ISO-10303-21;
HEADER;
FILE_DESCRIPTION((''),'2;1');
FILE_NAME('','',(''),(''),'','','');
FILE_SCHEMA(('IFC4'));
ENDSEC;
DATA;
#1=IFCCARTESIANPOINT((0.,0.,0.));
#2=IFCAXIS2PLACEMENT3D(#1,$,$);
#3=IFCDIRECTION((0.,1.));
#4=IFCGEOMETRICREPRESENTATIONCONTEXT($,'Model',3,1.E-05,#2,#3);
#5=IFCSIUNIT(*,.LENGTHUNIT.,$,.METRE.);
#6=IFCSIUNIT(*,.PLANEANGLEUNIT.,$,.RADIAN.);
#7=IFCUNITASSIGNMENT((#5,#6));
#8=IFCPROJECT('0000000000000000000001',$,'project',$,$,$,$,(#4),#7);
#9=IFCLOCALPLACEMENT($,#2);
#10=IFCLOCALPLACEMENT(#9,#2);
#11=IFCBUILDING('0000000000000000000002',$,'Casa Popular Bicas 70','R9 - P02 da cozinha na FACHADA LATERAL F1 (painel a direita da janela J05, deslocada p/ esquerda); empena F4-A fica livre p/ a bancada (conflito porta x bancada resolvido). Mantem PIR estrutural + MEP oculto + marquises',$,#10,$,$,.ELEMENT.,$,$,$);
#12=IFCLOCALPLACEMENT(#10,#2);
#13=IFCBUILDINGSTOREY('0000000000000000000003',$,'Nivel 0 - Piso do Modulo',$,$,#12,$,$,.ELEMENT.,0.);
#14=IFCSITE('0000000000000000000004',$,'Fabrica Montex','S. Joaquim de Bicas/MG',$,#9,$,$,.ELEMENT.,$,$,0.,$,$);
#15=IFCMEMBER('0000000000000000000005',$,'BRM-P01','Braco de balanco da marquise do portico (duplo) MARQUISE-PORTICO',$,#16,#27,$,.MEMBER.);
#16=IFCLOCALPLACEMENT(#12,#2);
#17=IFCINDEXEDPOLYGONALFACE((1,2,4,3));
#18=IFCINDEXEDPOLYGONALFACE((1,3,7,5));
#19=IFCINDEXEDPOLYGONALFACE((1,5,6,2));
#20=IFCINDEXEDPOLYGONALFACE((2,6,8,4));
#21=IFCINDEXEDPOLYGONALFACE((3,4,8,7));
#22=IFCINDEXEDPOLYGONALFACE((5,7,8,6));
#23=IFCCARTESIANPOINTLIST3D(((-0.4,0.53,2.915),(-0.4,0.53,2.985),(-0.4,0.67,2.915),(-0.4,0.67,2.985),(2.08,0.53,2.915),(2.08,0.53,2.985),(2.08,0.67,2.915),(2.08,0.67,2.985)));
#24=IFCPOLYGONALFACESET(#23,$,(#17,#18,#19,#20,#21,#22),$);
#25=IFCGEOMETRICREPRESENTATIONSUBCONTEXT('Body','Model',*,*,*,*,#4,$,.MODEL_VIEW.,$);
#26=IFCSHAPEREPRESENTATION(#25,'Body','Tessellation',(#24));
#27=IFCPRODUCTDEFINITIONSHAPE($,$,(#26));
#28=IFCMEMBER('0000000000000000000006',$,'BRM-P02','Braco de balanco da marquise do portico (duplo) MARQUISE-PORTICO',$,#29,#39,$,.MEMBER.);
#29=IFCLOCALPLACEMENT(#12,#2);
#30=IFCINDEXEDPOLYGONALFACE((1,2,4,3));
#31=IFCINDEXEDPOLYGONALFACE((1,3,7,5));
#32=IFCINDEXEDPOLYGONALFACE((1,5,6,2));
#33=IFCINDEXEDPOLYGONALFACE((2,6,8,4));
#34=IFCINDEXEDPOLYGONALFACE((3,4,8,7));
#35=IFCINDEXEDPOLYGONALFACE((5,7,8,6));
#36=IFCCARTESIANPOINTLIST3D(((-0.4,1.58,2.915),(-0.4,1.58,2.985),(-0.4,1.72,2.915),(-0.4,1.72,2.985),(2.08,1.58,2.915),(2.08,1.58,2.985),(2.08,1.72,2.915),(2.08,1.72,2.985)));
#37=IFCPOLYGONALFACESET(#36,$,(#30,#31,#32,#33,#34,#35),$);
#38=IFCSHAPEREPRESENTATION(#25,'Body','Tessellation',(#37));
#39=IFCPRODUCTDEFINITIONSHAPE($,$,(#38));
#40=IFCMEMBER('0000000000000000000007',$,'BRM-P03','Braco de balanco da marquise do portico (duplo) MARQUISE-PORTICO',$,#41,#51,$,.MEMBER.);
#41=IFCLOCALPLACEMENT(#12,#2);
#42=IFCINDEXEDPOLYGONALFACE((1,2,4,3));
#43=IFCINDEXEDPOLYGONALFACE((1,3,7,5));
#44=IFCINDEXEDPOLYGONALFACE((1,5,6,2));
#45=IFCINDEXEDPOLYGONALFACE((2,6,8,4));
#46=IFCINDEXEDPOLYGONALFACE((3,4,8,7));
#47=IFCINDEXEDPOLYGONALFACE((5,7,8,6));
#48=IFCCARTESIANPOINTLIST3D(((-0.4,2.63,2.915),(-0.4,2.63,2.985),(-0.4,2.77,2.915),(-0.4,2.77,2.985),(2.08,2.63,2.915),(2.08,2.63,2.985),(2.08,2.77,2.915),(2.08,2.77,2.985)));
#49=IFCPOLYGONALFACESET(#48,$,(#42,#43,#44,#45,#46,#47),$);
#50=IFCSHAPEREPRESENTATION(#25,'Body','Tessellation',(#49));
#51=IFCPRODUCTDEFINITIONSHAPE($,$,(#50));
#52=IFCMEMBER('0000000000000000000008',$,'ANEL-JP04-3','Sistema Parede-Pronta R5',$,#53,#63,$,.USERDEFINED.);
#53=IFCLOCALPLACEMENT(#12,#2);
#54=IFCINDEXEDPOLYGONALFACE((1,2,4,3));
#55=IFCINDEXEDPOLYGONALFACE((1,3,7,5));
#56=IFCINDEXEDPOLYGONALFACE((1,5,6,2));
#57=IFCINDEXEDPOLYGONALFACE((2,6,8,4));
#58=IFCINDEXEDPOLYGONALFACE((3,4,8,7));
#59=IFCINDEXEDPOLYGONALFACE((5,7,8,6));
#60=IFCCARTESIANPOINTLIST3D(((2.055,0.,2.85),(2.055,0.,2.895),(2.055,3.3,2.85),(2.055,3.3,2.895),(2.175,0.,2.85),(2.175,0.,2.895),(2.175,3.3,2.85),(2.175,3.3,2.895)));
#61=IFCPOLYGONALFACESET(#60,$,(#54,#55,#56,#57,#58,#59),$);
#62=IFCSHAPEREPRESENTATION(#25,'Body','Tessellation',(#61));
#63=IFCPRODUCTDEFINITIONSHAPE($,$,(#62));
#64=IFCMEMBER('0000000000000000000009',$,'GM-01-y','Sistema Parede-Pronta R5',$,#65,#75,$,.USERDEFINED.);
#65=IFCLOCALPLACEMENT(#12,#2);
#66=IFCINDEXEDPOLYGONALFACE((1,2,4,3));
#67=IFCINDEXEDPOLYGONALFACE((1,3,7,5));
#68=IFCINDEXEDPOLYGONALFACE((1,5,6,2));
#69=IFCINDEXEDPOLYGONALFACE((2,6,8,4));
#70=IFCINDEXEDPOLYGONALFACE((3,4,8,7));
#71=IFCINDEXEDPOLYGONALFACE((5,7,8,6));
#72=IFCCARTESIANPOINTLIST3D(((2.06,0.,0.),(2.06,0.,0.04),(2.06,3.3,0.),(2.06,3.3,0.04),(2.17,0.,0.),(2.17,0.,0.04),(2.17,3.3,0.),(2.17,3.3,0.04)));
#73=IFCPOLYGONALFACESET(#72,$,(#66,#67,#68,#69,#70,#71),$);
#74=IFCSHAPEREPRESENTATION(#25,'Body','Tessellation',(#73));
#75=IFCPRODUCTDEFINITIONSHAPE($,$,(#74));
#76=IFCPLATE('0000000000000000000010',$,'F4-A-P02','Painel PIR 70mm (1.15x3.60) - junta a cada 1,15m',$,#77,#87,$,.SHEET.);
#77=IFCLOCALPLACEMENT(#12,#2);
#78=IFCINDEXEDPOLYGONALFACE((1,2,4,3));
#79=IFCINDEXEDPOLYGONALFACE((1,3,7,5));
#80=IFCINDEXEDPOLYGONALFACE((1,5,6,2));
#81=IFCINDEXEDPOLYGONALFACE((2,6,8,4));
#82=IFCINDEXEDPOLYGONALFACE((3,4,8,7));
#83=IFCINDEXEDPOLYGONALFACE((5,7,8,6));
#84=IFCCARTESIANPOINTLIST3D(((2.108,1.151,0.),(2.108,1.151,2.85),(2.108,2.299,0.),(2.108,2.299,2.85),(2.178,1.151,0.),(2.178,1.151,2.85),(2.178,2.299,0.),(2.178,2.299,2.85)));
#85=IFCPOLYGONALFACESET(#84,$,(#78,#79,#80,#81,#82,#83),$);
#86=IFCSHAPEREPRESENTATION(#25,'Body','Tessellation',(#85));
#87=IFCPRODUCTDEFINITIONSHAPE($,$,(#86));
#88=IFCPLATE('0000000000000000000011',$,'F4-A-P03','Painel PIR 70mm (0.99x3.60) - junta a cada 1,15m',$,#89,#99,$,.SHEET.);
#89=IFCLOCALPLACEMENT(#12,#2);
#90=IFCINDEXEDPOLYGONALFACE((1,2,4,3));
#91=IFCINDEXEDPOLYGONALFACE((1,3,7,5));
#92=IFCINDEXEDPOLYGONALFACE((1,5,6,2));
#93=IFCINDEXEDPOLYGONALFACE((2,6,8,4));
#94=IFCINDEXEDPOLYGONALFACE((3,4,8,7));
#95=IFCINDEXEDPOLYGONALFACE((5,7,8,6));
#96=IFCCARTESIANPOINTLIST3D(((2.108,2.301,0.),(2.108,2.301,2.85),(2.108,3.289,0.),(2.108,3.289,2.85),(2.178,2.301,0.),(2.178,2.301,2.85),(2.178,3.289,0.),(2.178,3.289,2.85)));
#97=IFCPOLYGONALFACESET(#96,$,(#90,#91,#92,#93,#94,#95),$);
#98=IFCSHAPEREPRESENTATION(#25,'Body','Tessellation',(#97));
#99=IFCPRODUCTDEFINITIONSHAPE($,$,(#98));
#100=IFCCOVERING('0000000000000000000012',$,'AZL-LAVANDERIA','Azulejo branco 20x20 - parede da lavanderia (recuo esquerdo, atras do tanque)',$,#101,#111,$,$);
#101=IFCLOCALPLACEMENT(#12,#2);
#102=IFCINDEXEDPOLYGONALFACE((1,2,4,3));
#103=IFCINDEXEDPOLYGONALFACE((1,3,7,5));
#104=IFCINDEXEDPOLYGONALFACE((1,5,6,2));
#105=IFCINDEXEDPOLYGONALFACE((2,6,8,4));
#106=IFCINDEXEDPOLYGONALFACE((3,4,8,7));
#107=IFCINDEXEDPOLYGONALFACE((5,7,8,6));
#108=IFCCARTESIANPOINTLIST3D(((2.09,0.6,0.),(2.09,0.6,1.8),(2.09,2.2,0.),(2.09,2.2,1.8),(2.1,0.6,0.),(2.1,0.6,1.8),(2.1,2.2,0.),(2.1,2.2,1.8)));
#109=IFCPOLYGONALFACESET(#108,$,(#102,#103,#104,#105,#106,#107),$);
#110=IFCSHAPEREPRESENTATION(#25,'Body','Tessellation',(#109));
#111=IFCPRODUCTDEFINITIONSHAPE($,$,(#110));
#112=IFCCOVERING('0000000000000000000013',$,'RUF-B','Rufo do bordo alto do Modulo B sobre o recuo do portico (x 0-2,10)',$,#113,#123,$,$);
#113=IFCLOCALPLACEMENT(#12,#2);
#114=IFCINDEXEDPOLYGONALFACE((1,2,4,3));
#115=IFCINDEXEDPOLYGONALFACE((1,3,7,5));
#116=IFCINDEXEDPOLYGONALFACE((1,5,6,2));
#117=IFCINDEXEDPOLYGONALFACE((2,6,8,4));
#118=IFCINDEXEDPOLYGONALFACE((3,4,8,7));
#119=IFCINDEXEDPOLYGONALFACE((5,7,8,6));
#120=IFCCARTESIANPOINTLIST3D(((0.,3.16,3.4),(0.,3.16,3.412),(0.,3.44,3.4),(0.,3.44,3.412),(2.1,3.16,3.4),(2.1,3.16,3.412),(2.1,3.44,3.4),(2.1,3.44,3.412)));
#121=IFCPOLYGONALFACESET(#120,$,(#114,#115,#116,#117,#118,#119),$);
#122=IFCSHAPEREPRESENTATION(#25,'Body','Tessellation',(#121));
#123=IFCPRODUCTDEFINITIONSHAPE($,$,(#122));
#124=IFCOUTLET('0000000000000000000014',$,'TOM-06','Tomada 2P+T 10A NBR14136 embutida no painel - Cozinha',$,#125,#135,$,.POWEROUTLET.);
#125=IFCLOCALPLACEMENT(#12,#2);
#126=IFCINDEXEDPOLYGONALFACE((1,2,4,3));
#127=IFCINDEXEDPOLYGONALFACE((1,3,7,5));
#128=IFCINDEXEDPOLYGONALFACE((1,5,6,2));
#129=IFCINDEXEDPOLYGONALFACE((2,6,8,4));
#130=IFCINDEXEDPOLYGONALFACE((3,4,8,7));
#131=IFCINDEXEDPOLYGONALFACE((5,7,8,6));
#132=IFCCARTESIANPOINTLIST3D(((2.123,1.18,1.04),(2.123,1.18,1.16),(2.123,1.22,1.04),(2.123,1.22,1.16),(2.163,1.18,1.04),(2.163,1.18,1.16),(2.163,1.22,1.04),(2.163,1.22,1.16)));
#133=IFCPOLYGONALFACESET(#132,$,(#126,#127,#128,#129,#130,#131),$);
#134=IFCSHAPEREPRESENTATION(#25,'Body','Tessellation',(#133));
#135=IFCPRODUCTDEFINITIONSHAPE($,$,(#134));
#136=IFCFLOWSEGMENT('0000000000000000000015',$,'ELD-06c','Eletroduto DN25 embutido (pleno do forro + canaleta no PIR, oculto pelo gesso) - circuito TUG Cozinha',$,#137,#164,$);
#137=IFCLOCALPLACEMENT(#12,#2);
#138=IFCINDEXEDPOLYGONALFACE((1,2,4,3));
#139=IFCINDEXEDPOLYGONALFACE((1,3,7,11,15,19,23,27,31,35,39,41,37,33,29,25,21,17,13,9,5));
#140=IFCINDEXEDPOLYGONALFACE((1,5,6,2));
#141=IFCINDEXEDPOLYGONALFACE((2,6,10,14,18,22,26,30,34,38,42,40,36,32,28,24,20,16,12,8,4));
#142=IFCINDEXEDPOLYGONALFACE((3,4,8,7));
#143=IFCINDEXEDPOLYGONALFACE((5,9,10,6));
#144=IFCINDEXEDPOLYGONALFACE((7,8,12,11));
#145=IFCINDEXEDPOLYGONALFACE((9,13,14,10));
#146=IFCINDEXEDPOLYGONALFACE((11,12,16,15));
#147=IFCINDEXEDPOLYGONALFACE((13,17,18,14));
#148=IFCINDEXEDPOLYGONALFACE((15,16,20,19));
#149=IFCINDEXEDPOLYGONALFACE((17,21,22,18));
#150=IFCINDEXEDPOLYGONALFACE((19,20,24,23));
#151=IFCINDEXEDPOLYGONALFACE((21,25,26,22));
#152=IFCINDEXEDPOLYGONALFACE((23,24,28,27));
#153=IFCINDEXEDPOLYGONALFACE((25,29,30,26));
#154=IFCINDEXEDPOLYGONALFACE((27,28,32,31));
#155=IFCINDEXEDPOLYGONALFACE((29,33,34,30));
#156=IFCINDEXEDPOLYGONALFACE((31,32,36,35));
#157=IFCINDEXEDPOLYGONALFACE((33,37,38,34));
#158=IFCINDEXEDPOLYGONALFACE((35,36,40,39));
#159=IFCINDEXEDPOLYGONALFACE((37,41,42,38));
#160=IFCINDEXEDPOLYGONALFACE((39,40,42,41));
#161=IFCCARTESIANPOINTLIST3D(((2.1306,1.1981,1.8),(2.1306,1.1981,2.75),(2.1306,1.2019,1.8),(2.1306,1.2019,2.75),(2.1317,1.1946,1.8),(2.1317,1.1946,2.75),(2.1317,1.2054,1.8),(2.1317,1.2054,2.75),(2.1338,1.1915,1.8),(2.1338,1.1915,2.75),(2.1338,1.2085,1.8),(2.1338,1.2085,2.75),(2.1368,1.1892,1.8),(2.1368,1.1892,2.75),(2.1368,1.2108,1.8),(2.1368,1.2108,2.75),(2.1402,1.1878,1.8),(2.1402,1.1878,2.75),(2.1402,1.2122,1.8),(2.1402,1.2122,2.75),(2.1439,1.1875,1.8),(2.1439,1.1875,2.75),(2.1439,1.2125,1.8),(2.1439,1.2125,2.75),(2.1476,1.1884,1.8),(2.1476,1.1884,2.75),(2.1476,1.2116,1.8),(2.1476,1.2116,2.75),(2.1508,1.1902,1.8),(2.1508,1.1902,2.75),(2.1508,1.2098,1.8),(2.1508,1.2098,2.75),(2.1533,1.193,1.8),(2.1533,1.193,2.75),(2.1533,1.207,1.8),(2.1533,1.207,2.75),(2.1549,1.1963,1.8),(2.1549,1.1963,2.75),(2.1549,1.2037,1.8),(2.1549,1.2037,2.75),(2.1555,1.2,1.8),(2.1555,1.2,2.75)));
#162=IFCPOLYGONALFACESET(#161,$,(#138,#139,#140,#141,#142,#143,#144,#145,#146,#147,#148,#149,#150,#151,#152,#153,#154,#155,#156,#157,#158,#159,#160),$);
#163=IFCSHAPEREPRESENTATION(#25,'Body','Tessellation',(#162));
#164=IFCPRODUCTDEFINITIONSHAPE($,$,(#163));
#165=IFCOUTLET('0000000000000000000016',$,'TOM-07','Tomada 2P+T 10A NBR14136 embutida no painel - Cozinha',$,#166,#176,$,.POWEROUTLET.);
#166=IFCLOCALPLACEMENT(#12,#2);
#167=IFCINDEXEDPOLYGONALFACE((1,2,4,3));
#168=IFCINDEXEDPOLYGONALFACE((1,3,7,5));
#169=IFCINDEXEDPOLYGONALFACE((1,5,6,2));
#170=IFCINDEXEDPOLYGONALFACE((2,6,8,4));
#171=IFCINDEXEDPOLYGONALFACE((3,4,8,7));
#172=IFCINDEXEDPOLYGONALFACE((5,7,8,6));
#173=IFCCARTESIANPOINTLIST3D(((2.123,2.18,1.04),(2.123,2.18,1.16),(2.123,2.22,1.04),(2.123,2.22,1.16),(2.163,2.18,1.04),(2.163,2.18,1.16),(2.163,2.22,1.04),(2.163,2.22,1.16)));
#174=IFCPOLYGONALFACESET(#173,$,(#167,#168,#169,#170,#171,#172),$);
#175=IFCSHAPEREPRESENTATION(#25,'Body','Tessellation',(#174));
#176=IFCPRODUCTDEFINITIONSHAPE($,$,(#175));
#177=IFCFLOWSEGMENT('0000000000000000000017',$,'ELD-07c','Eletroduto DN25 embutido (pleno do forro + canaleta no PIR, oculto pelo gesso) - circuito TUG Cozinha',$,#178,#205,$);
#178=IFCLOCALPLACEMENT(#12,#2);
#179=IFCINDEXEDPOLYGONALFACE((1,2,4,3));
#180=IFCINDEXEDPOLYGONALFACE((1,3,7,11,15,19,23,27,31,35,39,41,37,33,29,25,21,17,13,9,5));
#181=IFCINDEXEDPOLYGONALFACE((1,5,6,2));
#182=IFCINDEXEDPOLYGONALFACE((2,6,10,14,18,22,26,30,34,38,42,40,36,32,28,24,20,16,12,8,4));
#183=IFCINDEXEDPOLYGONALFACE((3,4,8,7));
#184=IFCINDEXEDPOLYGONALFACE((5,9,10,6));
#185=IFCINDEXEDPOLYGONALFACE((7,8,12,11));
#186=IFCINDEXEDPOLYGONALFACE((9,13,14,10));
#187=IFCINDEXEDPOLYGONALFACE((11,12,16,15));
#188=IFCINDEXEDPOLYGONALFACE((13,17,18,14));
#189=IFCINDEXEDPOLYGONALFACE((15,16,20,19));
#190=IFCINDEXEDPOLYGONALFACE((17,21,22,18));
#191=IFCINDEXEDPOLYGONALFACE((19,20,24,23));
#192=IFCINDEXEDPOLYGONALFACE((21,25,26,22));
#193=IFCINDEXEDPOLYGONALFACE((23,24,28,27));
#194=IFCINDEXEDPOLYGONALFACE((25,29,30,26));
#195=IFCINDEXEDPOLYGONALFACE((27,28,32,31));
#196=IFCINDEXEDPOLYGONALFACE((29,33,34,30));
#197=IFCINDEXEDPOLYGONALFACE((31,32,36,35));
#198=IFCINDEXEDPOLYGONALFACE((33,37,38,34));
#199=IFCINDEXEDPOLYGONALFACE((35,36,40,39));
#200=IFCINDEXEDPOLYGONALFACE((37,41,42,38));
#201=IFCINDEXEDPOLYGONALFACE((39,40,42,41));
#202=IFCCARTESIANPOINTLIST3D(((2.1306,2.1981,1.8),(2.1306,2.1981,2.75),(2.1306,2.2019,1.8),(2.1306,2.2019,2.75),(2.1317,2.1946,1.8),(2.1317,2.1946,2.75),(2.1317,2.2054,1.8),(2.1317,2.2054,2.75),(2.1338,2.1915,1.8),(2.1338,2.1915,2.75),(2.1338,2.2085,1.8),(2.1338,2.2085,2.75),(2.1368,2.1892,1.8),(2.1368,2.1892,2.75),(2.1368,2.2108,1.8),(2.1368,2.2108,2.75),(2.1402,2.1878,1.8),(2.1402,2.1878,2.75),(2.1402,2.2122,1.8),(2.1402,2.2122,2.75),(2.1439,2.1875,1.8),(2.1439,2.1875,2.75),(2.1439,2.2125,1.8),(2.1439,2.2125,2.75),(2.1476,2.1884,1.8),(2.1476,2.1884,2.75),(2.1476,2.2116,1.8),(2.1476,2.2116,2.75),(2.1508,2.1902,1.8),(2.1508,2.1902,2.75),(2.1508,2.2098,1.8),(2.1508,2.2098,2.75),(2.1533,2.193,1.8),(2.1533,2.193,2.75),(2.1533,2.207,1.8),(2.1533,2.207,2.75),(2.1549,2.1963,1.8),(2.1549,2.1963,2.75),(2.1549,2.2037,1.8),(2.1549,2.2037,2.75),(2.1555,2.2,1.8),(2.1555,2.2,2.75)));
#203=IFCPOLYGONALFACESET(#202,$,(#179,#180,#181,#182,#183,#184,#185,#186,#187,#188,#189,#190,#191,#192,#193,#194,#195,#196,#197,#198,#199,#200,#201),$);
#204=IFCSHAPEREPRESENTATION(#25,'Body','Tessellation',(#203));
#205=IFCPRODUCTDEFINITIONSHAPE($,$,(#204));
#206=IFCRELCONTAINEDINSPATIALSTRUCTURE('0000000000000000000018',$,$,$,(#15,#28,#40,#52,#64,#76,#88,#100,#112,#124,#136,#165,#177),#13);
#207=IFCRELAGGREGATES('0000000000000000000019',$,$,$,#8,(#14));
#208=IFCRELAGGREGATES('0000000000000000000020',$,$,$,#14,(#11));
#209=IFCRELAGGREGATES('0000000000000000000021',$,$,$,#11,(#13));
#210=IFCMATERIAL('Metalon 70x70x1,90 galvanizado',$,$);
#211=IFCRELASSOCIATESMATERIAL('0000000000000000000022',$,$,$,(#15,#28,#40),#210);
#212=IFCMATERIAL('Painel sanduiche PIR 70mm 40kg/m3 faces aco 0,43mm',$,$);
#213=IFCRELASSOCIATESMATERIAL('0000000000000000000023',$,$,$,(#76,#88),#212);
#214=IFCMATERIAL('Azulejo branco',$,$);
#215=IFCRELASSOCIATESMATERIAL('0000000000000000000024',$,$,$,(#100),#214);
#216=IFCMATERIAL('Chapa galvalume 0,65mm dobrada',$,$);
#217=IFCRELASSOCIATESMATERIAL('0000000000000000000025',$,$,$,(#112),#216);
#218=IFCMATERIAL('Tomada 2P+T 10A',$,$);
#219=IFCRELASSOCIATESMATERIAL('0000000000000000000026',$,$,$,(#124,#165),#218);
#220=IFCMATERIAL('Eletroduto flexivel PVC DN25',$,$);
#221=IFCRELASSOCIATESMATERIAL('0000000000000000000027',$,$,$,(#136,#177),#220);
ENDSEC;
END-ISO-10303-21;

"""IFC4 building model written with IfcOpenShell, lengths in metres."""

from ifc_helpers import new_model, si_unit, direction, frame, frame_2d, origin, origin_2d, place, context, subcontext, project, spatial, rectangle, circle, extrude, material, element, save


model = new_model("IFC4")

# Units and contexts
model_context = context("Model", 3, precision=1e-05, world=origin(), true_north=direction((0.0, 1.0)))
body_context = subcontext(model_context, "Body", "Model", "MODEL_VIEW")
ifc_project = project(units=[si_unit("LENGTHUNIT", "METRE"), si_unit("PLANEANGLEUNIT", "RADIAN")], contexts=[model_context])

# Site, building, storey
site_placement = place(None, origin())
site = spatial("IfcSite", under=ifc_project, at=site_placement, Name="Fabrica Montex", Description="S. Joaquim de Bicas/MG", CompositionType="ELEMENT", RefElevation=0.0)
building_placement = place(site_placement, origin())
building = spatial("IfcBuilding", under=site, at=building_placement, Name="Casa Popular Bicas 70", Description="R9 - P02 da cozinha na FACHADA LATERAL F1 (painel a direita da janela J05, deslocada p/ esquerda); empena F4-A fica livre p/ a bancada (conflito porta x bancada resolvido). Mantem PIR estrutural + MEP oculto + marquises", CompositionType="ELEMENT")
storey_placement = place(building_placement, origin())
storey = spatial("IfcBuildingStorey", under=building, at=storey_placement, Name="Nivel 0 - Piso do Modulo", CompositionType="ELEMENT", Elevation=0.0)

# Members
ifc_material_1 = material(Name="Metalon 70x70x1,90 galvanizado")
for number, where, z_axis, x_axis, name in (
    (1, (2.08, 0.6, 2.95), (-1.0, 0.0, 0.0), (0.0, 0.0, 1.0), "BRM-P01"),
    (2, (2.08, 1.65, 2.95), (-1.0, 0.0, 0.0), (0.0, 0.0, 1.0), "BRM-P02"),
    (3, (2.08, 2.7, 2.95), (-1.0, 0.0, 0.0), (0.0, 0.0, 1.0), "BRM-P03"),
):
    element("IfcMember", number, at=place(storey_placement, frame(where, z_axis=z_axis, x_axis=x_axis)), inside=storey, material=ifc_material_1, Name=name, Description="Braco de balanco da marquise do portico (duplo) MARQUISE-PORTICO", PredefinedType="MEMBER", context=body_context, shape_type="SweptSolid", body=[
        extrude(rectangle(XDim=0.07, YDim=0.14, at=origin_2d()), origin(), (0.0, 0.0, 1.0), 2.48),
    ])
member_1_placement = place(storey_placement, frame((2.115, 1.65, 2.85)))
element("IfcMember", 4, at=member_1_placement, inside=storey, Name="ANEL-JP04-3", Description="Sistema Parede-Pronta R5", PredefinedType="USERDEFINED", context=body_context, shape_type="SweptSolid", body=[
    extrude(rectangle(XDim=0.12, YDim=3.3, at=origin_2d()), origin(), (0.0, 0.0, 1.0), 0.045),
])
member_2_placement = place(storey_placement, frame((2.115, 1.65, 0.0)))
element("IfcMember", 5, at=member_2_placement, inside=storey, Name="GM-01-y", Description="Sistema Parede-Pronta R5", PredefinedType="USERDEFINED", context=body_context, shape_type="SweptSolid", body=[
    extrude(rectangle(XDim=0.11, YDim=3.3, at=origin_2d()), origin(), (0.0, 0.0, 1.0), 0.04),
])

# Plates
ifc_material_2 = material(Name="Painel sanduiche PIR 70mm 40kg/m3 faces aco 0,43mm")
plate_1_placement = place(storey_placement, frame((2.143, 1.151, 0.0), x_axis=(0.0, 1.0, 0.0)))
element("IfcPlate", 6, at=plate_1_placement, inside=storey, material=ifc_material_2, Name="F4-A-P02", Description="Painel PIR 70mm (1.15x3.60) - junta a cada 1,15m", PredefinedType="SHEET", context=body_context, shape_type="SweptSolid", body=[
    extrude(rectangle(XDim=1.148, YDim=0.07, at=frame_2d((0.574, 0.0))), origin(), (0.0, 0.0, 1.0), 2.85),
])
plate_2_placement = place(storey_placement, frame((2.143, 2.301, 0.0), x_axis=(0.0, 1.0, 0.0)))
element("IfcPlate", 7, at=plate_2_placement, inside=storey, material=ifc_material_2, Name="F4-A-P03", Description="Painel PIR 70mm (0.99x3.60) - junta a cada 1,15m", PredefinedType="SHEET", context=body_context, shape_type="SweptSolid", body=[
    extrude(rectangle(XDim=0.988, YDim=0.07, at=frame_2d((0.494, 0.0))), origin(), (0.0, 0.0, 1.0), 2.85),
])

# Coverings
ifc_material_3 = material(Name="Azulejo branco")
covering_1_placement = place(storey_placement, frame((2.095, 0.6, 0.0), x_axis=(0.0, 1.0, 0.0)))
element("IfcCovering", 8, at=covering_1_placement, inside=storey, material=ifc_material_3, Name="AZL-LAVANDERIA", Description="Azulejo branco 20x20 - parede da lavanderia (recuo esquerdo, atras do tanque)", context=body_context, shape_type="SweptSolid", body=[
    extrude(rectangle(XDim=1.6, YDim=0.01, at=frame_2d((0.8, 0.0))), origin(), (0.0, 0.0, 1.0), 1.8),
])
ifc_material_4 = material(Name="Chapa galvalume 0,65mm dobrada")
covering_2_placement = place(storey_placement, frame((0.0, 3.16, 3.4), x_axis=(1.0, 0.0, 0.0)))
element("IfcCovering", 9, at=covering_2_placement, inside=storey, material=ifc_material_4, Name="RUF-B", Description="Rufo do bordo alto do Modulo B sobre o recuo do portico (x 0-2,10)", context=body_context, shape_type="SweptSolid", body=[
    extrude(rectangle(XDim=2.1, YDim=0.28, at=frame_2d((1.05, 0.14))), origin(), (0.0, 0.0, 1.0), 0.012),
])

# Outlet
ifc_material_5 = material(Name="Tomada 2P+T 10A")
outlet_1_placement = place(storey_placement, frame((2.123, 1.18, 1.04)))
element("IfcOutlet", 10, at=outlet_1_placement, inside=storey, material=ifc_material_5, Name="TOM-06", Description="Tomada 2P+T 10A NBR14136 embutida no painel - Cozinha", PredefinedType="POWEROUTLET", context=body_context, shape_type="SweptSolid", body=[
    extrude(rectangle(XDim=0.04, YDim=0.04, at=frame_2d((0.02, 0.02))), origin(), (0.0, 0.0, 1.0), 0.12),
])

# Flow segment
ifc_material_6 = material(Name="Eletroduto flexivel PVC DN25")
flow_segment_1_placement = place(storey_placement, frame((2.143, 1.2, 2.75), z_axis=(0.0, 0.0, -1.0), x_axis=(1.0, 0.0, 0.0)))
element("IfcFlowSegment", 11, at=flow_segment_1_placement, inside=storey, material=ifc_material_6, Name="ELD-06c", Description="Eletroduto DN25 embutido (pleno do forro + canaleta no PIR, oculto pelo gesso) - circuito TUG Cozinha", context=body_context, shape_type="SweptSolid", body=[
    extrude(circle(Radius=0.0125, at=origin_2d()), origin(), (0.0, 0.0, 1.0), 0.95),
])

# Outlet
outlet_2_placement = place(storey_placement, frame((2.123, 2.18, 1.04)))
element("IfcOutlet", 12, at=outlet_2_placement, inside=storey, material=ifc_material_5, Name="TOM-07", Description="Tomada 2P+T 10A NBR14136 embutida no painel - Cozinha", PredefinedType="POWEROUTLET", context=body_context, shape_type="SweptSolid", body=[
    extrude(rectangle(XDim=0.04, YDim=0.04, at=frame_2d((0.02, 0.02))), origin(), (0.0, 0.0, 1.0), 0.12),
])

# Flow segment
flow_segment_2_placement = place(storey_placement, frame((2.143, 2.2, 2.75), z_axis=(0.0, 0.0, -1.0), x_axis=(1.0, 0.0, 0.0)))
element("IfcFlowSegment", 13, at=flow_segment_2_placement, inside=storey, material=ifc_material_6, Name="ELD-07c", Description="Eletroduto DN25 embutido (pleno do forro + canaleta no PIR, oculto pelo gesso) - circuito TUG Cozinha", context=body_context, shape_type="SweptSolid", body=[
    extrude(circle(Radius=0.0125, at=origin_2d()), origin(), (0.0, 0.0, 1.0), 0.95),
])

save(model, "model.ifc")
